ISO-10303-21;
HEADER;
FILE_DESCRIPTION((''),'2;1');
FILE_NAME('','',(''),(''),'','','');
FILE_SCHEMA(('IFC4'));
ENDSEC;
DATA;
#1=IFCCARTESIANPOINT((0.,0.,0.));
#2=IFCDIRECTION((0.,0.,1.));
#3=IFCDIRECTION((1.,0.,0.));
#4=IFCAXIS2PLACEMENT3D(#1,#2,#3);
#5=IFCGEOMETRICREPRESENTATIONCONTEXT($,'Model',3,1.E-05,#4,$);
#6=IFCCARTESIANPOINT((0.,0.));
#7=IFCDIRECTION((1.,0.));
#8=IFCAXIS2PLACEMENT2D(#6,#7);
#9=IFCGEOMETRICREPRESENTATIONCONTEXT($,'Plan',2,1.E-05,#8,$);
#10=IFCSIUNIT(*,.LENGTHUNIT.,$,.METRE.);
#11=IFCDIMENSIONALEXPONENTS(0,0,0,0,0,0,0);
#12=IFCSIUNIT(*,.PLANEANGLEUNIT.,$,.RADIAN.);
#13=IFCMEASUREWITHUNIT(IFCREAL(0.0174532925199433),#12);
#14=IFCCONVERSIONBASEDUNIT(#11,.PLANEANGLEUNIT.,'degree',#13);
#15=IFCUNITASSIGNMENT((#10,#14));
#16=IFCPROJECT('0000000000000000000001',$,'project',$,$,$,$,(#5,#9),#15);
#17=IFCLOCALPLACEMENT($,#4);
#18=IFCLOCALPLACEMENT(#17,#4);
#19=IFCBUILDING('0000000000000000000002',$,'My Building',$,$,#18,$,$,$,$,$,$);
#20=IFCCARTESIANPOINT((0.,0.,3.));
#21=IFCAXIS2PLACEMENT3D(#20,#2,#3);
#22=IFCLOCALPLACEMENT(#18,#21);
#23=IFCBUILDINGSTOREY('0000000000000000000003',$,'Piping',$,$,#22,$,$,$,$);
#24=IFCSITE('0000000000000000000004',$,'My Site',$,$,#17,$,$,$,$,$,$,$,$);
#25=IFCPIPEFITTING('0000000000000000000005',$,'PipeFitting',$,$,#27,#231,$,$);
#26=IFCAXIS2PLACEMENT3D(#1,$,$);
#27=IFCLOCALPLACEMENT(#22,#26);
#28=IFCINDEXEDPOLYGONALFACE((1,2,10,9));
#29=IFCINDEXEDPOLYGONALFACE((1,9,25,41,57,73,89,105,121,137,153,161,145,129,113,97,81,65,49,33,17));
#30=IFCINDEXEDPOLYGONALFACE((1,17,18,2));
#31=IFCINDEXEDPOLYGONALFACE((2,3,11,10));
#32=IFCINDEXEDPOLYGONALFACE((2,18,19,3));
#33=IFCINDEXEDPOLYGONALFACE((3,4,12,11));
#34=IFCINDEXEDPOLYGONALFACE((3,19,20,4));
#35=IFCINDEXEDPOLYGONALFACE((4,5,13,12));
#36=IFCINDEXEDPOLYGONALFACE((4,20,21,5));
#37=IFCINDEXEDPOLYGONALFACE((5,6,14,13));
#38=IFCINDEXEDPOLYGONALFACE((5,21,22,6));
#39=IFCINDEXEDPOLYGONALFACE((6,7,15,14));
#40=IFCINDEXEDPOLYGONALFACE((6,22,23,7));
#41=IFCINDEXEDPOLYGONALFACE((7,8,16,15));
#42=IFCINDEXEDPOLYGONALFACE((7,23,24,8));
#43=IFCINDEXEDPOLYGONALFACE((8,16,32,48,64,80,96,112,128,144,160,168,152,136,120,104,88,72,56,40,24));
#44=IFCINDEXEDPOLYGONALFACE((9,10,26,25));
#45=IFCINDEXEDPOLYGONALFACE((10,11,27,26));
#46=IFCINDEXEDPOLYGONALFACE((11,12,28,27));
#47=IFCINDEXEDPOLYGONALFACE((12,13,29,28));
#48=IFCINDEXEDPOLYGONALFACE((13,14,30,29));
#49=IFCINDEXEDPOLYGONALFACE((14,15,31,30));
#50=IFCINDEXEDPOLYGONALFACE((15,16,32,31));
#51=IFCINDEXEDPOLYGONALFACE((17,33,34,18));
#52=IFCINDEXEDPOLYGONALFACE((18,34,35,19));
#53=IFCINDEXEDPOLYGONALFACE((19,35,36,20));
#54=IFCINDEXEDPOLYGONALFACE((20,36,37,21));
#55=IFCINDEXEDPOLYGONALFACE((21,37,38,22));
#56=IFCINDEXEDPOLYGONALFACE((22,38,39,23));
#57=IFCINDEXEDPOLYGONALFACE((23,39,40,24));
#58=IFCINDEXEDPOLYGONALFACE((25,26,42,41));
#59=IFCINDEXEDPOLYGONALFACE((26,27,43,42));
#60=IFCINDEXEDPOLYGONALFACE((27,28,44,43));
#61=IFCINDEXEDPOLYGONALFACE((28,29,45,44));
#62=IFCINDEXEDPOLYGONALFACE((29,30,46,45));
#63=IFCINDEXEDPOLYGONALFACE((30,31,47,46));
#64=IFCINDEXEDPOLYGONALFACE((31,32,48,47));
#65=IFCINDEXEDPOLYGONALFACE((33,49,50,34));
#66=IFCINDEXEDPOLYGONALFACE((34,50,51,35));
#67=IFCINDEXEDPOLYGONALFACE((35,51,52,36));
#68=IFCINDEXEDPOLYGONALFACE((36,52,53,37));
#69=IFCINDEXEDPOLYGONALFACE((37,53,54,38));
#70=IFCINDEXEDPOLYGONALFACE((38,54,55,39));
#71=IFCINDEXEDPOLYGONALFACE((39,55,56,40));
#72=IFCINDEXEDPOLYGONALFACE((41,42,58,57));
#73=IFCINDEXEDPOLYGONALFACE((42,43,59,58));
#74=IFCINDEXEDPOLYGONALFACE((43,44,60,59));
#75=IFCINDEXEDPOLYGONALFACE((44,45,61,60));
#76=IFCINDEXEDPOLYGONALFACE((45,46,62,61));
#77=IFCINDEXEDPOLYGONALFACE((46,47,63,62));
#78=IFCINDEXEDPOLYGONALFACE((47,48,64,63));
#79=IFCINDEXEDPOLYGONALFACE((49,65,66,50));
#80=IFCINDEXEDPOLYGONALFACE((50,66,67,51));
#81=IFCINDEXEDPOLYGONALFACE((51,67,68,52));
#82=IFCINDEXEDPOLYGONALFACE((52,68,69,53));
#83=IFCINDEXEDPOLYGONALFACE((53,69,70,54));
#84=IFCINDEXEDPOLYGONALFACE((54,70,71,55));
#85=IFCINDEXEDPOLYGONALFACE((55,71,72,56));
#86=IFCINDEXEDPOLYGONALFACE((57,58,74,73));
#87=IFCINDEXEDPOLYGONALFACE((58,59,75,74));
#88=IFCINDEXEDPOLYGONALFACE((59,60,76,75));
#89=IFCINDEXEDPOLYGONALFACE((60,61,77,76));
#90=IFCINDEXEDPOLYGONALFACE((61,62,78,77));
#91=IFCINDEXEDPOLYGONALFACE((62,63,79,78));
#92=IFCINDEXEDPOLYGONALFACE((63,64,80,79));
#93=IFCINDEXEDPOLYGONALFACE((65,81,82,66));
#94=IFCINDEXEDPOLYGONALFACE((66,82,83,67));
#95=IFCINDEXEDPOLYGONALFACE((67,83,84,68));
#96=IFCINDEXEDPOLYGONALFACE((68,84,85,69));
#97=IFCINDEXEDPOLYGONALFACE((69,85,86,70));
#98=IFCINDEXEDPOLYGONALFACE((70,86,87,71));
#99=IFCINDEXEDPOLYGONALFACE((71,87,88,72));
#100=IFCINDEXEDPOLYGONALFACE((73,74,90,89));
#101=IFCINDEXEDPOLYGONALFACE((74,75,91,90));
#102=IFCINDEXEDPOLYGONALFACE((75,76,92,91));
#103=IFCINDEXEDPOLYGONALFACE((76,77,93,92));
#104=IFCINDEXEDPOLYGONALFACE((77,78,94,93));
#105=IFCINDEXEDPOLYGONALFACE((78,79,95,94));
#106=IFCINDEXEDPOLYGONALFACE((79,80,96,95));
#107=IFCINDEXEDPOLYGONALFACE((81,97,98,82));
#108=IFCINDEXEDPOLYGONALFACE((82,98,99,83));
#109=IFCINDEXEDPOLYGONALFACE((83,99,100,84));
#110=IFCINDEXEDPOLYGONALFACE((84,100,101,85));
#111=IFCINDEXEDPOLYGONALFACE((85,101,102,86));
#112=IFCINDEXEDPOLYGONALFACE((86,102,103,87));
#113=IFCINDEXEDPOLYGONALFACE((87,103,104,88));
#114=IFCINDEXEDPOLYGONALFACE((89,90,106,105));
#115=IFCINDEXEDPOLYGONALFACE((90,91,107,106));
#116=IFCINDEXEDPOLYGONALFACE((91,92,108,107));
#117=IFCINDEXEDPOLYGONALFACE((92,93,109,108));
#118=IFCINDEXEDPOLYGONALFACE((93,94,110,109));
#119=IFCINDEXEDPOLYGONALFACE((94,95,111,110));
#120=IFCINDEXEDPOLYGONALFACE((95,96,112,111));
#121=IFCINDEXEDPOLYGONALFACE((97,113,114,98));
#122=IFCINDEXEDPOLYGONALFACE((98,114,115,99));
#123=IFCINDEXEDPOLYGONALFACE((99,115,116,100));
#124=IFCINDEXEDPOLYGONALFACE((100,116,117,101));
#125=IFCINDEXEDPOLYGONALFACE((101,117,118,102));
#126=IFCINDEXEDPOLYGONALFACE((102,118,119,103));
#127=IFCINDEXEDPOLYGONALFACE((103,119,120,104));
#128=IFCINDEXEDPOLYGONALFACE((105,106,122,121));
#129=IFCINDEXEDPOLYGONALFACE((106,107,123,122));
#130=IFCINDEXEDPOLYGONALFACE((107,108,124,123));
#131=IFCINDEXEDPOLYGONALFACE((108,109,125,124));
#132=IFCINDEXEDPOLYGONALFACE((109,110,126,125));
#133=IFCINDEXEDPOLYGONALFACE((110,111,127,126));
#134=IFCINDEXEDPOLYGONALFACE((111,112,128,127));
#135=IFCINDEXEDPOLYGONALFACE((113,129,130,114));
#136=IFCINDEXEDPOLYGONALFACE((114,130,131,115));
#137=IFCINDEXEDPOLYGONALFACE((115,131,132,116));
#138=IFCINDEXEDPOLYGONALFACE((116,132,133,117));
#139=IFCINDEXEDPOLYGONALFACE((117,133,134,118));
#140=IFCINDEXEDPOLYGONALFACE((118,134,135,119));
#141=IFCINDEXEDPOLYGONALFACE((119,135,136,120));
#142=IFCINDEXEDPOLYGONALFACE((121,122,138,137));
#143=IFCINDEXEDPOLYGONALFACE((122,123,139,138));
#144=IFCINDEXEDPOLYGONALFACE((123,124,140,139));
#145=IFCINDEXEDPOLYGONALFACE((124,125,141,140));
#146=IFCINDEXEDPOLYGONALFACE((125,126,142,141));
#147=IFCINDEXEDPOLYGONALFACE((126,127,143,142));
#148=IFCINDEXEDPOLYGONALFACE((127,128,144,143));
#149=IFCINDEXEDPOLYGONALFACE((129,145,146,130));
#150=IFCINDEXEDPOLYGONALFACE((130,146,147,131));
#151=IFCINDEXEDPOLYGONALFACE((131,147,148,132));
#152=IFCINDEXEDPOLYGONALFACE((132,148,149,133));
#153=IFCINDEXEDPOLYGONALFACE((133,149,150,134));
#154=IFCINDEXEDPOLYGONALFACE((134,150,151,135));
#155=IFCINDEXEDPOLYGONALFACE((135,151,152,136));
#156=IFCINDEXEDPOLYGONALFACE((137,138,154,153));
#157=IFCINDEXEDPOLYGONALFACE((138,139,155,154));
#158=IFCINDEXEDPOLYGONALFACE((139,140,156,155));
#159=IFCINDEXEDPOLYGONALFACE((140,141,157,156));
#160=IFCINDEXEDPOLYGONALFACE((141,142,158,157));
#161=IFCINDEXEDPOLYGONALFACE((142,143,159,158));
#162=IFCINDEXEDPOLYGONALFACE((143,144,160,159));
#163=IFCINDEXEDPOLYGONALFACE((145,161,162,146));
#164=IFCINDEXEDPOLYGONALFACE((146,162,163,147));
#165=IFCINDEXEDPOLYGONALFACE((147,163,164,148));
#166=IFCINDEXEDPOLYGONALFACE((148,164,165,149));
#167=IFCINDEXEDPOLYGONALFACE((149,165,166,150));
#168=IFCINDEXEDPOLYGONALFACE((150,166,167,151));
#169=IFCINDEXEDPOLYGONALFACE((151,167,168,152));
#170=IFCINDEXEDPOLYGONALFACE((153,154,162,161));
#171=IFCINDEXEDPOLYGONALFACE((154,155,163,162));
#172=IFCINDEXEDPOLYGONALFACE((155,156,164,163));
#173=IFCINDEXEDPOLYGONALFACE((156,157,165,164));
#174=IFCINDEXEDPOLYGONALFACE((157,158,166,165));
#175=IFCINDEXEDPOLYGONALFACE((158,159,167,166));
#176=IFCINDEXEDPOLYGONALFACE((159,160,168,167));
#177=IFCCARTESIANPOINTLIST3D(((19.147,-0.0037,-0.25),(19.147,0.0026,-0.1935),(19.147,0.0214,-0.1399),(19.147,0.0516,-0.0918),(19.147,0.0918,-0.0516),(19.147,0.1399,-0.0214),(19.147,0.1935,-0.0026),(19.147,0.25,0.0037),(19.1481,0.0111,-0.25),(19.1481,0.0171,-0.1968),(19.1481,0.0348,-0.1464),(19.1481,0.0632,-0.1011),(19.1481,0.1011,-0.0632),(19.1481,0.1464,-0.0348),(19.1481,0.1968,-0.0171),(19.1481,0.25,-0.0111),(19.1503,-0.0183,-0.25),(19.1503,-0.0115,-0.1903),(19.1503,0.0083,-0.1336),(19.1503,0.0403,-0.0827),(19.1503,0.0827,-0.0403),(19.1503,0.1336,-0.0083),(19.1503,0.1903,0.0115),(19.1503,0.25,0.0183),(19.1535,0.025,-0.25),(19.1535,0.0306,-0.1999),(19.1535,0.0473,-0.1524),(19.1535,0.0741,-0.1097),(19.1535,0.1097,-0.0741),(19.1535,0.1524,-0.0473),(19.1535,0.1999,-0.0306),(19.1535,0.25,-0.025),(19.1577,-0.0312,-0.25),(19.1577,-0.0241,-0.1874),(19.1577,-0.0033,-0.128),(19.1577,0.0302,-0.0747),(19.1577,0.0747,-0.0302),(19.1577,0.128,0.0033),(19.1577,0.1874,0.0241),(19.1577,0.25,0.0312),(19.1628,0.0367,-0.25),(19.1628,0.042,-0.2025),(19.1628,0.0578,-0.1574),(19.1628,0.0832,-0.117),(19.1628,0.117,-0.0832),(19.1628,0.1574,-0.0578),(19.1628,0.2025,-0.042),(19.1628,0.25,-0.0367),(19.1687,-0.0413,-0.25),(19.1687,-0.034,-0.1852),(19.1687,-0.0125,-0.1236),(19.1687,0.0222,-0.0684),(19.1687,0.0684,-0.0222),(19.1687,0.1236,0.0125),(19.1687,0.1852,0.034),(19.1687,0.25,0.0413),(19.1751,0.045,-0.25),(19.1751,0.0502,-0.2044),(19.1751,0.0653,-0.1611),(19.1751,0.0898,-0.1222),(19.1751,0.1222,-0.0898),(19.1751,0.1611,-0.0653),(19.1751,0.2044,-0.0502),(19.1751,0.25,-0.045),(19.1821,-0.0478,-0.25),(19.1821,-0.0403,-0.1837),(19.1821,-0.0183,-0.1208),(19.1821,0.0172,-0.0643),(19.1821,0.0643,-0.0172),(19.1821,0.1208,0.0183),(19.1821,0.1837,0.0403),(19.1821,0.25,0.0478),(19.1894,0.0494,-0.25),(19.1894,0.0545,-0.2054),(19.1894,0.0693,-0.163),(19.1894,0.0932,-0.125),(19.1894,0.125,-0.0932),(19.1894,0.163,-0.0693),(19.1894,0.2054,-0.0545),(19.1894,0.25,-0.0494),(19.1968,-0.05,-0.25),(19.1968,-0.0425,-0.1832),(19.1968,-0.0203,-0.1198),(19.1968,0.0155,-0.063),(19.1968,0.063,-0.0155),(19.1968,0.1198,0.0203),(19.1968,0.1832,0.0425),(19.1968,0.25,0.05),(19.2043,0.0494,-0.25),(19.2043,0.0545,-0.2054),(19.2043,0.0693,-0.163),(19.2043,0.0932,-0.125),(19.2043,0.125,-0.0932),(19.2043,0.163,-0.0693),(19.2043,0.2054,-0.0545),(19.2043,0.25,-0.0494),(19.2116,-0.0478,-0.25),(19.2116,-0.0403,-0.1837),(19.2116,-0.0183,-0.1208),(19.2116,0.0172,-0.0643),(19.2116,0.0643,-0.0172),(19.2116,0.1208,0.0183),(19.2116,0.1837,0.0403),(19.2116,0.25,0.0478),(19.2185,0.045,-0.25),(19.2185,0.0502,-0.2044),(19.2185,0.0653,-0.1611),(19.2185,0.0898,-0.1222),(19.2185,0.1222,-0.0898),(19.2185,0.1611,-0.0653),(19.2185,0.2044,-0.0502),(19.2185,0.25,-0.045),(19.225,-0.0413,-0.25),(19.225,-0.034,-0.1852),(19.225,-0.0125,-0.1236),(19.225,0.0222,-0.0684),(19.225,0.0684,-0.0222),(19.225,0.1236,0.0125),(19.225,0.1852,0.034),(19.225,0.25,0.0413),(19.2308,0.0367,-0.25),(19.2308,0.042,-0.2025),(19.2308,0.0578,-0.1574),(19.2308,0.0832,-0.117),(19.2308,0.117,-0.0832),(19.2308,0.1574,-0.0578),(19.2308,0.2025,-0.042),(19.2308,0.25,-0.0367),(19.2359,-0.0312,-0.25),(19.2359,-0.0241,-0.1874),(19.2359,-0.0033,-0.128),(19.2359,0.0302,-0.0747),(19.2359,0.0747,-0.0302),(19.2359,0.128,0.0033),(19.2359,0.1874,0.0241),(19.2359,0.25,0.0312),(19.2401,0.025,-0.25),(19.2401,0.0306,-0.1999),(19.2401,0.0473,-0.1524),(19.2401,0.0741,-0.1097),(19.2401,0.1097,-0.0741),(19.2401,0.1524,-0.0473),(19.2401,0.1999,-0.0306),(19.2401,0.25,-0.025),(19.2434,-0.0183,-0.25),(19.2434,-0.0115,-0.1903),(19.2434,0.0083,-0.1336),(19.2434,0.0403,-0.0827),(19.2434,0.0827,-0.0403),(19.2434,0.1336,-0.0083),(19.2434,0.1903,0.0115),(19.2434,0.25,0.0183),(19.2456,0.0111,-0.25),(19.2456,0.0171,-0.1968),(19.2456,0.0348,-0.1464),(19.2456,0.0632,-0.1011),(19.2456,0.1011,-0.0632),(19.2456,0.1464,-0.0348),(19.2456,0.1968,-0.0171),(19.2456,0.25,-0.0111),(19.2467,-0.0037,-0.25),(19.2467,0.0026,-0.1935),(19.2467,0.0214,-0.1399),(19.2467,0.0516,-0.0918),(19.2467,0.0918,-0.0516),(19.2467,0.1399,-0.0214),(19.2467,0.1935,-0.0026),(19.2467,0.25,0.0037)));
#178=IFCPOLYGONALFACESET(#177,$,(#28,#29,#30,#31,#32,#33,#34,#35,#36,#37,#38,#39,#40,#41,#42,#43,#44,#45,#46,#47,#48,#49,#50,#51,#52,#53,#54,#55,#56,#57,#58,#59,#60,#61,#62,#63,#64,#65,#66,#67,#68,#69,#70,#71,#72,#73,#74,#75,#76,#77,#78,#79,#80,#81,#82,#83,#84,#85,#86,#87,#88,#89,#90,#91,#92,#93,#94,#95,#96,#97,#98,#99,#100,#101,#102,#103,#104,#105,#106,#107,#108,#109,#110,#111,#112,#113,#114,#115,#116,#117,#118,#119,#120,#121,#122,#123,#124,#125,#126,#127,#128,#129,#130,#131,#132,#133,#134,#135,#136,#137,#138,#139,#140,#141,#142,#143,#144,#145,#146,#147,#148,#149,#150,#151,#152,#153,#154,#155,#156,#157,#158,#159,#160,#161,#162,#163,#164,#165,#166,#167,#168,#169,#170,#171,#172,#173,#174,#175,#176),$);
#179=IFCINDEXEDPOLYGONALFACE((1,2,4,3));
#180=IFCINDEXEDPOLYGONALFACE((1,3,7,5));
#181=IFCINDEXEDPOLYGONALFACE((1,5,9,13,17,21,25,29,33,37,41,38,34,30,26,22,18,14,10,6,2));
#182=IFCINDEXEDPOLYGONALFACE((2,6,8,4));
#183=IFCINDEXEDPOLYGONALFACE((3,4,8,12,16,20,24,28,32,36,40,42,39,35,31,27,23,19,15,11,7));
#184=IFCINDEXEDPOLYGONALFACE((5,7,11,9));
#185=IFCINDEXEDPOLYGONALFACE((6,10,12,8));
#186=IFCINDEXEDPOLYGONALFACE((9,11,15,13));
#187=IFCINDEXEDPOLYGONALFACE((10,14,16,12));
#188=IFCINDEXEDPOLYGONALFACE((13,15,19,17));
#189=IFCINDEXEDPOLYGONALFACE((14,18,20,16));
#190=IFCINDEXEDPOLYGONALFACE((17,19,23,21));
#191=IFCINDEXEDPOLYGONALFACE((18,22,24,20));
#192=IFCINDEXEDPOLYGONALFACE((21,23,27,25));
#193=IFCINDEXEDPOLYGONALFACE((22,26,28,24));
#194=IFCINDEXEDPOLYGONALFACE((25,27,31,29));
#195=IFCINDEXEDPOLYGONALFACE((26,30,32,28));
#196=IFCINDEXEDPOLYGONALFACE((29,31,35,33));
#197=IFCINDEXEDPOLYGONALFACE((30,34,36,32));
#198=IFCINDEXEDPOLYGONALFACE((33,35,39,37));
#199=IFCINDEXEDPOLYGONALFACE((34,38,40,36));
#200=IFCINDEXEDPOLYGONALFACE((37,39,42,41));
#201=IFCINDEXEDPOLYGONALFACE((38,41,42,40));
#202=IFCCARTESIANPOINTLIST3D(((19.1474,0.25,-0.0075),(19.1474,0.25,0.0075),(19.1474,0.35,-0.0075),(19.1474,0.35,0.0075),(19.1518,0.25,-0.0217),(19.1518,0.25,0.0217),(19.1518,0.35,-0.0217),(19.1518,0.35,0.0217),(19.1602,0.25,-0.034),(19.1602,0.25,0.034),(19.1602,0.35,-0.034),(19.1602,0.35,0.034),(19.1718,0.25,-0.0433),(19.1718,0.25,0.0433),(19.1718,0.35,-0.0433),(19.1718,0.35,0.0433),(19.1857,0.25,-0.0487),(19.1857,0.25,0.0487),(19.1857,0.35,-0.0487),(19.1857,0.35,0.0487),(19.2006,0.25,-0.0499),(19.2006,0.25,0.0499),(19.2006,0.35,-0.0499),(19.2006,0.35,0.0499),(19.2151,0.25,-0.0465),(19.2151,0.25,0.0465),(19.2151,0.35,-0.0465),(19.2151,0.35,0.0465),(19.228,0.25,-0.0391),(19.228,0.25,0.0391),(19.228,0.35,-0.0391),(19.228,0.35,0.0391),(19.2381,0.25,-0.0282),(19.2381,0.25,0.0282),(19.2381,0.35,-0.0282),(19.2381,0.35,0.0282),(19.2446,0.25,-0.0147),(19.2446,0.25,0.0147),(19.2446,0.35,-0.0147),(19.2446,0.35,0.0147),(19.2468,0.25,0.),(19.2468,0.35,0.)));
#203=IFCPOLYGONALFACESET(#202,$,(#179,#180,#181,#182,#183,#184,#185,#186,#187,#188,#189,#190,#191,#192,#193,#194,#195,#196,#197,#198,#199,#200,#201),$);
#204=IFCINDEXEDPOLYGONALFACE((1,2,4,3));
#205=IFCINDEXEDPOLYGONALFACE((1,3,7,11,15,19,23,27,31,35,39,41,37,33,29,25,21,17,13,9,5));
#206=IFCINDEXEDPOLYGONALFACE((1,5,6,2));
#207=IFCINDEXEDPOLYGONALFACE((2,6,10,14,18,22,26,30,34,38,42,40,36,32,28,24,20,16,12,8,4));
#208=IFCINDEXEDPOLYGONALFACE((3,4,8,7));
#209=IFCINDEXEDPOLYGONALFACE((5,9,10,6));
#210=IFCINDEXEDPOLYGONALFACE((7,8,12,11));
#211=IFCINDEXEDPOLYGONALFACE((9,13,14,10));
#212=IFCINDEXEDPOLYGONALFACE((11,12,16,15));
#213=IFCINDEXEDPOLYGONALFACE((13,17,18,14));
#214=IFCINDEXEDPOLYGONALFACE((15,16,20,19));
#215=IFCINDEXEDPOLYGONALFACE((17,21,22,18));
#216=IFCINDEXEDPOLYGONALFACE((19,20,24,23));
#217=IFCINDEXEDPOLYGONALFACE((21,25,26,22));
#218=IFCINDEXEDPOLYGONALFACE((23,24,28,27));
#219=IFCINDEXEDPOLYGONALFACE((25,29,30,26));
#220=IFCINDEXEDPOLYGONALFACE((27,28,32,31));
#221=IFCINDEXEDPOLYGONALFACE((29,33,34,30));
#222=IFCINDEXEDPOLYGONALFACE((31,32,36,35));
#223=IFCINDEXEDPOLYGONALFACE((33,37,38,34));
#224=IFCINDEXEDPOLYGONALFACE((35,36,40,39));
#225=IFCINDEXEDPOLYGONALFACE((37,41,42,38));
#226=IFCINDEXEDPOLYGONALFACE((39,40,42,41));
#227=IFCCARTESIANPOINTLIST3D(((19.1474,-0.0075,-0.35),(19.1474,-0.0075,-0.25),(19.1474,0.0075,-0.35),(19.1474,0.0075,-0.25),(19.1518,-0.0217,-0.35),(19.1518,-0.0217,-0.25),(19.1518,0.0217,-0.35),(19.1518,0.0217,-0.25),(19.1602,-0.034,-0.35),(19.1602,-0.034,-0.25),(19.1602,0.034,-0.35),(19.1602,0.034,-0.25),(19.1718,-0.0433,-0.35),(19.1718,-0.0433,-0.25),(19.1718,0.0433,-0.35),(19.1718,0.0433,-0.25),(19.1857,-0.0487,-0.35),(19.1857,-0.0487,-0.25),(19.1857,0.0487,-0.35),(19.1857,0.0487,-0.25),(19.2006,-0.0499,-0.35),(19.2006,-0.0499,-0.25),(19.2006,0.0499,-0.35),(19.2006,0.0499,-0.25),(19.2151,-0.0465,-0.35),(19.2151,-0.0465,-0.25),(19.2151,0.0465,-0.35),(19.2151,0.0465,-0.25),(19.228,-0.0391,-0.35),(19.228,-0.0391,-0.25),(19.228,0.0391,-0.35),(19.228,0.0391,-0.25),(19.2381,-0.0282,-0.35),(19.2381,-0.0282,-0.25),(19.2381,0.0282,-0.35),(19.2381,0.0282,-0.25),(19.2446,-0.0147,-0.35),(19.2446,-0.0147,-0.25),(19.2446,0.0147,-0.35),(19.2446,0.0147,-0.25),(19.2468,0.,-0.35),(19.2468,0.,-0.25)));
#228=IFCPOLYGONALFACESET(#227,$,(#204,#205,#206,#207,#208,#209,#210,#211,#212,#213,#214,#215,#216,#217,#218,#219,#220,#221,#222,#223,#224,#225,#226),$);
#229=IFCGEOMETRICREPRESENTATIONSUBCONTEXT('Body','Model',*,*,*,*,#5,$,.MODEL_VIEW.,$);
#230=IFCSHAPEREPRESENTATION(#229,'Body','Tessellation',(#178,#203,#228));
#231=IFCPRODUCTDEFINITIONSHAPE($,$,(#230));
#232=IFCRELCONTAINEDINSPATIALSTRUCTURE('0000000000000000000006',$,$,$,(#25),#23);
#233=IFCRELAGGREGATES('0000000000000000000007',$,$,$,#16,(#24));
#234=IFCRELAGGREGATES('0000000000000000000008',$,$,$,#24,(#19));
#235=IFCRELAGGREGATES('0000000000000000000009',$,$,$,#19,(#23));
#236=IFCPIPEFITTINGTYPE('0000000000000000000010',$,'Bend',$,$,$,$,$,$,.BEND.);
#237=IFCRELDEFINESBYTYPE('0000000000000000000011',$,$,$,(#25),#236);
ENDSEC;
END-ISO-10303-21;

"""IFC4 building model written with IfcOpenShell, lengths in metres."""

from ifc_helpers import new_model, entity, si_unit, converted_unit, frame, origin_with_axes, origin_2d_with_axis, place, context, subcontext, project, spatial, circle, extrude, source, transform, mapped, type_object, type_shapes, element, save


model = new_model("IFC4")

# Units and contexts
model_context = context("Model", 3, precision=1e-05, world=origin_with_axes())
plan_context = context("Plan", 2, precision=1e-05, world=origin_2d_with_axis())
body_context = subcontext(model_context, "Body", "Model", "MODEL_VIEW")
ifc_project = project(units=[si_unit("LENGTHUNIT", "METRE"), converted_unit("PLANEANGLEUNIT", "degree", entity("IfcReal", 0.0174532925199433), si_unit("PLANEANGLEUNIT", "RADIAN"), dimensions=[0, 0, 0, 0, 0, 0, 0])], contexts=[model_context, plan_context])

# Site, building, storey
site_placement = place(None, origin_with_axes())
site = spatial("IfcSite", under=ifc_project, at=site_placement, Name="My Site")
building_placement = place(site_placement, origin_with_axes())
building = spatial("IfcBuilding", under=site, at=building_placement, Name="My Building")
storey_placement = place(building_placement, frame((0.0, 0.0, 3.0), z_axis=(0.0, 0.0, 1.0), x_axis=(1.0, 0.0, 0.0)))
storey = spatial("IfcBuildingStorey", under=building, at=storey_placement, Name="Piping")

# Pipe fitting
pipe_fitting_type = type_object("IfcPipeFittingType", Name="Bend", PredefinedType="BEND")
shared_shape = source(origin_with_axes(), body_context, "Body", "SolidModel", [
    entity("IfcSweptDiskSolid", entity("IfcIndexedPolyCurve", entity("IfcCartesianPointList3D", [[0.0, 0.0, 0.1], [0.0, -0.0732, 0.2768], [0.0, -0.25, 0.35]]), [entity("IfcArcIndex", [1, 2, 3])]), 0.05),
    extrude(circle(Radius=0.05), origin_with_axes(), (0.0, 0.0, 1.0), 0.1),
    extrude(circle(Radius=0.05), frame((0.0, -0.25, 0.35), z_axis=(0.0, -1.0, 0.0), x_axis=(1.0, 0.0, 0.0)), (0.0, 0.0, 1.0), 0.1),
])
type_shapes(pipe_fitting_type, [shared_shape])
for number, where, z_axis, x_axis, name in (
    (1, (19.1968, 0.35, 0.0), (0.0, -1.0, 0.0), (1.0, 0.0, 0.0), "PipeFitting"),
):
    element("IfcPipeFitting", number, at=place(storey_placement, frame(where, z_axis=z_axis, x_axis=x_axis)), inside=storey, type_object=pipe_fitting_type, Name=name, context=body_context, shape_type="MappedRepresentation", body=[
        mapped(shared_shape, transform((0.0, 0.0, 0.0), x_axis=(1.0, 0.0, 0.0), y_axis=(0.0, 1.0, 0.0), z_axis=(0.0, 0.0, 1.0), scale=1.0)),
    ])

save(model, "model.ifc")
